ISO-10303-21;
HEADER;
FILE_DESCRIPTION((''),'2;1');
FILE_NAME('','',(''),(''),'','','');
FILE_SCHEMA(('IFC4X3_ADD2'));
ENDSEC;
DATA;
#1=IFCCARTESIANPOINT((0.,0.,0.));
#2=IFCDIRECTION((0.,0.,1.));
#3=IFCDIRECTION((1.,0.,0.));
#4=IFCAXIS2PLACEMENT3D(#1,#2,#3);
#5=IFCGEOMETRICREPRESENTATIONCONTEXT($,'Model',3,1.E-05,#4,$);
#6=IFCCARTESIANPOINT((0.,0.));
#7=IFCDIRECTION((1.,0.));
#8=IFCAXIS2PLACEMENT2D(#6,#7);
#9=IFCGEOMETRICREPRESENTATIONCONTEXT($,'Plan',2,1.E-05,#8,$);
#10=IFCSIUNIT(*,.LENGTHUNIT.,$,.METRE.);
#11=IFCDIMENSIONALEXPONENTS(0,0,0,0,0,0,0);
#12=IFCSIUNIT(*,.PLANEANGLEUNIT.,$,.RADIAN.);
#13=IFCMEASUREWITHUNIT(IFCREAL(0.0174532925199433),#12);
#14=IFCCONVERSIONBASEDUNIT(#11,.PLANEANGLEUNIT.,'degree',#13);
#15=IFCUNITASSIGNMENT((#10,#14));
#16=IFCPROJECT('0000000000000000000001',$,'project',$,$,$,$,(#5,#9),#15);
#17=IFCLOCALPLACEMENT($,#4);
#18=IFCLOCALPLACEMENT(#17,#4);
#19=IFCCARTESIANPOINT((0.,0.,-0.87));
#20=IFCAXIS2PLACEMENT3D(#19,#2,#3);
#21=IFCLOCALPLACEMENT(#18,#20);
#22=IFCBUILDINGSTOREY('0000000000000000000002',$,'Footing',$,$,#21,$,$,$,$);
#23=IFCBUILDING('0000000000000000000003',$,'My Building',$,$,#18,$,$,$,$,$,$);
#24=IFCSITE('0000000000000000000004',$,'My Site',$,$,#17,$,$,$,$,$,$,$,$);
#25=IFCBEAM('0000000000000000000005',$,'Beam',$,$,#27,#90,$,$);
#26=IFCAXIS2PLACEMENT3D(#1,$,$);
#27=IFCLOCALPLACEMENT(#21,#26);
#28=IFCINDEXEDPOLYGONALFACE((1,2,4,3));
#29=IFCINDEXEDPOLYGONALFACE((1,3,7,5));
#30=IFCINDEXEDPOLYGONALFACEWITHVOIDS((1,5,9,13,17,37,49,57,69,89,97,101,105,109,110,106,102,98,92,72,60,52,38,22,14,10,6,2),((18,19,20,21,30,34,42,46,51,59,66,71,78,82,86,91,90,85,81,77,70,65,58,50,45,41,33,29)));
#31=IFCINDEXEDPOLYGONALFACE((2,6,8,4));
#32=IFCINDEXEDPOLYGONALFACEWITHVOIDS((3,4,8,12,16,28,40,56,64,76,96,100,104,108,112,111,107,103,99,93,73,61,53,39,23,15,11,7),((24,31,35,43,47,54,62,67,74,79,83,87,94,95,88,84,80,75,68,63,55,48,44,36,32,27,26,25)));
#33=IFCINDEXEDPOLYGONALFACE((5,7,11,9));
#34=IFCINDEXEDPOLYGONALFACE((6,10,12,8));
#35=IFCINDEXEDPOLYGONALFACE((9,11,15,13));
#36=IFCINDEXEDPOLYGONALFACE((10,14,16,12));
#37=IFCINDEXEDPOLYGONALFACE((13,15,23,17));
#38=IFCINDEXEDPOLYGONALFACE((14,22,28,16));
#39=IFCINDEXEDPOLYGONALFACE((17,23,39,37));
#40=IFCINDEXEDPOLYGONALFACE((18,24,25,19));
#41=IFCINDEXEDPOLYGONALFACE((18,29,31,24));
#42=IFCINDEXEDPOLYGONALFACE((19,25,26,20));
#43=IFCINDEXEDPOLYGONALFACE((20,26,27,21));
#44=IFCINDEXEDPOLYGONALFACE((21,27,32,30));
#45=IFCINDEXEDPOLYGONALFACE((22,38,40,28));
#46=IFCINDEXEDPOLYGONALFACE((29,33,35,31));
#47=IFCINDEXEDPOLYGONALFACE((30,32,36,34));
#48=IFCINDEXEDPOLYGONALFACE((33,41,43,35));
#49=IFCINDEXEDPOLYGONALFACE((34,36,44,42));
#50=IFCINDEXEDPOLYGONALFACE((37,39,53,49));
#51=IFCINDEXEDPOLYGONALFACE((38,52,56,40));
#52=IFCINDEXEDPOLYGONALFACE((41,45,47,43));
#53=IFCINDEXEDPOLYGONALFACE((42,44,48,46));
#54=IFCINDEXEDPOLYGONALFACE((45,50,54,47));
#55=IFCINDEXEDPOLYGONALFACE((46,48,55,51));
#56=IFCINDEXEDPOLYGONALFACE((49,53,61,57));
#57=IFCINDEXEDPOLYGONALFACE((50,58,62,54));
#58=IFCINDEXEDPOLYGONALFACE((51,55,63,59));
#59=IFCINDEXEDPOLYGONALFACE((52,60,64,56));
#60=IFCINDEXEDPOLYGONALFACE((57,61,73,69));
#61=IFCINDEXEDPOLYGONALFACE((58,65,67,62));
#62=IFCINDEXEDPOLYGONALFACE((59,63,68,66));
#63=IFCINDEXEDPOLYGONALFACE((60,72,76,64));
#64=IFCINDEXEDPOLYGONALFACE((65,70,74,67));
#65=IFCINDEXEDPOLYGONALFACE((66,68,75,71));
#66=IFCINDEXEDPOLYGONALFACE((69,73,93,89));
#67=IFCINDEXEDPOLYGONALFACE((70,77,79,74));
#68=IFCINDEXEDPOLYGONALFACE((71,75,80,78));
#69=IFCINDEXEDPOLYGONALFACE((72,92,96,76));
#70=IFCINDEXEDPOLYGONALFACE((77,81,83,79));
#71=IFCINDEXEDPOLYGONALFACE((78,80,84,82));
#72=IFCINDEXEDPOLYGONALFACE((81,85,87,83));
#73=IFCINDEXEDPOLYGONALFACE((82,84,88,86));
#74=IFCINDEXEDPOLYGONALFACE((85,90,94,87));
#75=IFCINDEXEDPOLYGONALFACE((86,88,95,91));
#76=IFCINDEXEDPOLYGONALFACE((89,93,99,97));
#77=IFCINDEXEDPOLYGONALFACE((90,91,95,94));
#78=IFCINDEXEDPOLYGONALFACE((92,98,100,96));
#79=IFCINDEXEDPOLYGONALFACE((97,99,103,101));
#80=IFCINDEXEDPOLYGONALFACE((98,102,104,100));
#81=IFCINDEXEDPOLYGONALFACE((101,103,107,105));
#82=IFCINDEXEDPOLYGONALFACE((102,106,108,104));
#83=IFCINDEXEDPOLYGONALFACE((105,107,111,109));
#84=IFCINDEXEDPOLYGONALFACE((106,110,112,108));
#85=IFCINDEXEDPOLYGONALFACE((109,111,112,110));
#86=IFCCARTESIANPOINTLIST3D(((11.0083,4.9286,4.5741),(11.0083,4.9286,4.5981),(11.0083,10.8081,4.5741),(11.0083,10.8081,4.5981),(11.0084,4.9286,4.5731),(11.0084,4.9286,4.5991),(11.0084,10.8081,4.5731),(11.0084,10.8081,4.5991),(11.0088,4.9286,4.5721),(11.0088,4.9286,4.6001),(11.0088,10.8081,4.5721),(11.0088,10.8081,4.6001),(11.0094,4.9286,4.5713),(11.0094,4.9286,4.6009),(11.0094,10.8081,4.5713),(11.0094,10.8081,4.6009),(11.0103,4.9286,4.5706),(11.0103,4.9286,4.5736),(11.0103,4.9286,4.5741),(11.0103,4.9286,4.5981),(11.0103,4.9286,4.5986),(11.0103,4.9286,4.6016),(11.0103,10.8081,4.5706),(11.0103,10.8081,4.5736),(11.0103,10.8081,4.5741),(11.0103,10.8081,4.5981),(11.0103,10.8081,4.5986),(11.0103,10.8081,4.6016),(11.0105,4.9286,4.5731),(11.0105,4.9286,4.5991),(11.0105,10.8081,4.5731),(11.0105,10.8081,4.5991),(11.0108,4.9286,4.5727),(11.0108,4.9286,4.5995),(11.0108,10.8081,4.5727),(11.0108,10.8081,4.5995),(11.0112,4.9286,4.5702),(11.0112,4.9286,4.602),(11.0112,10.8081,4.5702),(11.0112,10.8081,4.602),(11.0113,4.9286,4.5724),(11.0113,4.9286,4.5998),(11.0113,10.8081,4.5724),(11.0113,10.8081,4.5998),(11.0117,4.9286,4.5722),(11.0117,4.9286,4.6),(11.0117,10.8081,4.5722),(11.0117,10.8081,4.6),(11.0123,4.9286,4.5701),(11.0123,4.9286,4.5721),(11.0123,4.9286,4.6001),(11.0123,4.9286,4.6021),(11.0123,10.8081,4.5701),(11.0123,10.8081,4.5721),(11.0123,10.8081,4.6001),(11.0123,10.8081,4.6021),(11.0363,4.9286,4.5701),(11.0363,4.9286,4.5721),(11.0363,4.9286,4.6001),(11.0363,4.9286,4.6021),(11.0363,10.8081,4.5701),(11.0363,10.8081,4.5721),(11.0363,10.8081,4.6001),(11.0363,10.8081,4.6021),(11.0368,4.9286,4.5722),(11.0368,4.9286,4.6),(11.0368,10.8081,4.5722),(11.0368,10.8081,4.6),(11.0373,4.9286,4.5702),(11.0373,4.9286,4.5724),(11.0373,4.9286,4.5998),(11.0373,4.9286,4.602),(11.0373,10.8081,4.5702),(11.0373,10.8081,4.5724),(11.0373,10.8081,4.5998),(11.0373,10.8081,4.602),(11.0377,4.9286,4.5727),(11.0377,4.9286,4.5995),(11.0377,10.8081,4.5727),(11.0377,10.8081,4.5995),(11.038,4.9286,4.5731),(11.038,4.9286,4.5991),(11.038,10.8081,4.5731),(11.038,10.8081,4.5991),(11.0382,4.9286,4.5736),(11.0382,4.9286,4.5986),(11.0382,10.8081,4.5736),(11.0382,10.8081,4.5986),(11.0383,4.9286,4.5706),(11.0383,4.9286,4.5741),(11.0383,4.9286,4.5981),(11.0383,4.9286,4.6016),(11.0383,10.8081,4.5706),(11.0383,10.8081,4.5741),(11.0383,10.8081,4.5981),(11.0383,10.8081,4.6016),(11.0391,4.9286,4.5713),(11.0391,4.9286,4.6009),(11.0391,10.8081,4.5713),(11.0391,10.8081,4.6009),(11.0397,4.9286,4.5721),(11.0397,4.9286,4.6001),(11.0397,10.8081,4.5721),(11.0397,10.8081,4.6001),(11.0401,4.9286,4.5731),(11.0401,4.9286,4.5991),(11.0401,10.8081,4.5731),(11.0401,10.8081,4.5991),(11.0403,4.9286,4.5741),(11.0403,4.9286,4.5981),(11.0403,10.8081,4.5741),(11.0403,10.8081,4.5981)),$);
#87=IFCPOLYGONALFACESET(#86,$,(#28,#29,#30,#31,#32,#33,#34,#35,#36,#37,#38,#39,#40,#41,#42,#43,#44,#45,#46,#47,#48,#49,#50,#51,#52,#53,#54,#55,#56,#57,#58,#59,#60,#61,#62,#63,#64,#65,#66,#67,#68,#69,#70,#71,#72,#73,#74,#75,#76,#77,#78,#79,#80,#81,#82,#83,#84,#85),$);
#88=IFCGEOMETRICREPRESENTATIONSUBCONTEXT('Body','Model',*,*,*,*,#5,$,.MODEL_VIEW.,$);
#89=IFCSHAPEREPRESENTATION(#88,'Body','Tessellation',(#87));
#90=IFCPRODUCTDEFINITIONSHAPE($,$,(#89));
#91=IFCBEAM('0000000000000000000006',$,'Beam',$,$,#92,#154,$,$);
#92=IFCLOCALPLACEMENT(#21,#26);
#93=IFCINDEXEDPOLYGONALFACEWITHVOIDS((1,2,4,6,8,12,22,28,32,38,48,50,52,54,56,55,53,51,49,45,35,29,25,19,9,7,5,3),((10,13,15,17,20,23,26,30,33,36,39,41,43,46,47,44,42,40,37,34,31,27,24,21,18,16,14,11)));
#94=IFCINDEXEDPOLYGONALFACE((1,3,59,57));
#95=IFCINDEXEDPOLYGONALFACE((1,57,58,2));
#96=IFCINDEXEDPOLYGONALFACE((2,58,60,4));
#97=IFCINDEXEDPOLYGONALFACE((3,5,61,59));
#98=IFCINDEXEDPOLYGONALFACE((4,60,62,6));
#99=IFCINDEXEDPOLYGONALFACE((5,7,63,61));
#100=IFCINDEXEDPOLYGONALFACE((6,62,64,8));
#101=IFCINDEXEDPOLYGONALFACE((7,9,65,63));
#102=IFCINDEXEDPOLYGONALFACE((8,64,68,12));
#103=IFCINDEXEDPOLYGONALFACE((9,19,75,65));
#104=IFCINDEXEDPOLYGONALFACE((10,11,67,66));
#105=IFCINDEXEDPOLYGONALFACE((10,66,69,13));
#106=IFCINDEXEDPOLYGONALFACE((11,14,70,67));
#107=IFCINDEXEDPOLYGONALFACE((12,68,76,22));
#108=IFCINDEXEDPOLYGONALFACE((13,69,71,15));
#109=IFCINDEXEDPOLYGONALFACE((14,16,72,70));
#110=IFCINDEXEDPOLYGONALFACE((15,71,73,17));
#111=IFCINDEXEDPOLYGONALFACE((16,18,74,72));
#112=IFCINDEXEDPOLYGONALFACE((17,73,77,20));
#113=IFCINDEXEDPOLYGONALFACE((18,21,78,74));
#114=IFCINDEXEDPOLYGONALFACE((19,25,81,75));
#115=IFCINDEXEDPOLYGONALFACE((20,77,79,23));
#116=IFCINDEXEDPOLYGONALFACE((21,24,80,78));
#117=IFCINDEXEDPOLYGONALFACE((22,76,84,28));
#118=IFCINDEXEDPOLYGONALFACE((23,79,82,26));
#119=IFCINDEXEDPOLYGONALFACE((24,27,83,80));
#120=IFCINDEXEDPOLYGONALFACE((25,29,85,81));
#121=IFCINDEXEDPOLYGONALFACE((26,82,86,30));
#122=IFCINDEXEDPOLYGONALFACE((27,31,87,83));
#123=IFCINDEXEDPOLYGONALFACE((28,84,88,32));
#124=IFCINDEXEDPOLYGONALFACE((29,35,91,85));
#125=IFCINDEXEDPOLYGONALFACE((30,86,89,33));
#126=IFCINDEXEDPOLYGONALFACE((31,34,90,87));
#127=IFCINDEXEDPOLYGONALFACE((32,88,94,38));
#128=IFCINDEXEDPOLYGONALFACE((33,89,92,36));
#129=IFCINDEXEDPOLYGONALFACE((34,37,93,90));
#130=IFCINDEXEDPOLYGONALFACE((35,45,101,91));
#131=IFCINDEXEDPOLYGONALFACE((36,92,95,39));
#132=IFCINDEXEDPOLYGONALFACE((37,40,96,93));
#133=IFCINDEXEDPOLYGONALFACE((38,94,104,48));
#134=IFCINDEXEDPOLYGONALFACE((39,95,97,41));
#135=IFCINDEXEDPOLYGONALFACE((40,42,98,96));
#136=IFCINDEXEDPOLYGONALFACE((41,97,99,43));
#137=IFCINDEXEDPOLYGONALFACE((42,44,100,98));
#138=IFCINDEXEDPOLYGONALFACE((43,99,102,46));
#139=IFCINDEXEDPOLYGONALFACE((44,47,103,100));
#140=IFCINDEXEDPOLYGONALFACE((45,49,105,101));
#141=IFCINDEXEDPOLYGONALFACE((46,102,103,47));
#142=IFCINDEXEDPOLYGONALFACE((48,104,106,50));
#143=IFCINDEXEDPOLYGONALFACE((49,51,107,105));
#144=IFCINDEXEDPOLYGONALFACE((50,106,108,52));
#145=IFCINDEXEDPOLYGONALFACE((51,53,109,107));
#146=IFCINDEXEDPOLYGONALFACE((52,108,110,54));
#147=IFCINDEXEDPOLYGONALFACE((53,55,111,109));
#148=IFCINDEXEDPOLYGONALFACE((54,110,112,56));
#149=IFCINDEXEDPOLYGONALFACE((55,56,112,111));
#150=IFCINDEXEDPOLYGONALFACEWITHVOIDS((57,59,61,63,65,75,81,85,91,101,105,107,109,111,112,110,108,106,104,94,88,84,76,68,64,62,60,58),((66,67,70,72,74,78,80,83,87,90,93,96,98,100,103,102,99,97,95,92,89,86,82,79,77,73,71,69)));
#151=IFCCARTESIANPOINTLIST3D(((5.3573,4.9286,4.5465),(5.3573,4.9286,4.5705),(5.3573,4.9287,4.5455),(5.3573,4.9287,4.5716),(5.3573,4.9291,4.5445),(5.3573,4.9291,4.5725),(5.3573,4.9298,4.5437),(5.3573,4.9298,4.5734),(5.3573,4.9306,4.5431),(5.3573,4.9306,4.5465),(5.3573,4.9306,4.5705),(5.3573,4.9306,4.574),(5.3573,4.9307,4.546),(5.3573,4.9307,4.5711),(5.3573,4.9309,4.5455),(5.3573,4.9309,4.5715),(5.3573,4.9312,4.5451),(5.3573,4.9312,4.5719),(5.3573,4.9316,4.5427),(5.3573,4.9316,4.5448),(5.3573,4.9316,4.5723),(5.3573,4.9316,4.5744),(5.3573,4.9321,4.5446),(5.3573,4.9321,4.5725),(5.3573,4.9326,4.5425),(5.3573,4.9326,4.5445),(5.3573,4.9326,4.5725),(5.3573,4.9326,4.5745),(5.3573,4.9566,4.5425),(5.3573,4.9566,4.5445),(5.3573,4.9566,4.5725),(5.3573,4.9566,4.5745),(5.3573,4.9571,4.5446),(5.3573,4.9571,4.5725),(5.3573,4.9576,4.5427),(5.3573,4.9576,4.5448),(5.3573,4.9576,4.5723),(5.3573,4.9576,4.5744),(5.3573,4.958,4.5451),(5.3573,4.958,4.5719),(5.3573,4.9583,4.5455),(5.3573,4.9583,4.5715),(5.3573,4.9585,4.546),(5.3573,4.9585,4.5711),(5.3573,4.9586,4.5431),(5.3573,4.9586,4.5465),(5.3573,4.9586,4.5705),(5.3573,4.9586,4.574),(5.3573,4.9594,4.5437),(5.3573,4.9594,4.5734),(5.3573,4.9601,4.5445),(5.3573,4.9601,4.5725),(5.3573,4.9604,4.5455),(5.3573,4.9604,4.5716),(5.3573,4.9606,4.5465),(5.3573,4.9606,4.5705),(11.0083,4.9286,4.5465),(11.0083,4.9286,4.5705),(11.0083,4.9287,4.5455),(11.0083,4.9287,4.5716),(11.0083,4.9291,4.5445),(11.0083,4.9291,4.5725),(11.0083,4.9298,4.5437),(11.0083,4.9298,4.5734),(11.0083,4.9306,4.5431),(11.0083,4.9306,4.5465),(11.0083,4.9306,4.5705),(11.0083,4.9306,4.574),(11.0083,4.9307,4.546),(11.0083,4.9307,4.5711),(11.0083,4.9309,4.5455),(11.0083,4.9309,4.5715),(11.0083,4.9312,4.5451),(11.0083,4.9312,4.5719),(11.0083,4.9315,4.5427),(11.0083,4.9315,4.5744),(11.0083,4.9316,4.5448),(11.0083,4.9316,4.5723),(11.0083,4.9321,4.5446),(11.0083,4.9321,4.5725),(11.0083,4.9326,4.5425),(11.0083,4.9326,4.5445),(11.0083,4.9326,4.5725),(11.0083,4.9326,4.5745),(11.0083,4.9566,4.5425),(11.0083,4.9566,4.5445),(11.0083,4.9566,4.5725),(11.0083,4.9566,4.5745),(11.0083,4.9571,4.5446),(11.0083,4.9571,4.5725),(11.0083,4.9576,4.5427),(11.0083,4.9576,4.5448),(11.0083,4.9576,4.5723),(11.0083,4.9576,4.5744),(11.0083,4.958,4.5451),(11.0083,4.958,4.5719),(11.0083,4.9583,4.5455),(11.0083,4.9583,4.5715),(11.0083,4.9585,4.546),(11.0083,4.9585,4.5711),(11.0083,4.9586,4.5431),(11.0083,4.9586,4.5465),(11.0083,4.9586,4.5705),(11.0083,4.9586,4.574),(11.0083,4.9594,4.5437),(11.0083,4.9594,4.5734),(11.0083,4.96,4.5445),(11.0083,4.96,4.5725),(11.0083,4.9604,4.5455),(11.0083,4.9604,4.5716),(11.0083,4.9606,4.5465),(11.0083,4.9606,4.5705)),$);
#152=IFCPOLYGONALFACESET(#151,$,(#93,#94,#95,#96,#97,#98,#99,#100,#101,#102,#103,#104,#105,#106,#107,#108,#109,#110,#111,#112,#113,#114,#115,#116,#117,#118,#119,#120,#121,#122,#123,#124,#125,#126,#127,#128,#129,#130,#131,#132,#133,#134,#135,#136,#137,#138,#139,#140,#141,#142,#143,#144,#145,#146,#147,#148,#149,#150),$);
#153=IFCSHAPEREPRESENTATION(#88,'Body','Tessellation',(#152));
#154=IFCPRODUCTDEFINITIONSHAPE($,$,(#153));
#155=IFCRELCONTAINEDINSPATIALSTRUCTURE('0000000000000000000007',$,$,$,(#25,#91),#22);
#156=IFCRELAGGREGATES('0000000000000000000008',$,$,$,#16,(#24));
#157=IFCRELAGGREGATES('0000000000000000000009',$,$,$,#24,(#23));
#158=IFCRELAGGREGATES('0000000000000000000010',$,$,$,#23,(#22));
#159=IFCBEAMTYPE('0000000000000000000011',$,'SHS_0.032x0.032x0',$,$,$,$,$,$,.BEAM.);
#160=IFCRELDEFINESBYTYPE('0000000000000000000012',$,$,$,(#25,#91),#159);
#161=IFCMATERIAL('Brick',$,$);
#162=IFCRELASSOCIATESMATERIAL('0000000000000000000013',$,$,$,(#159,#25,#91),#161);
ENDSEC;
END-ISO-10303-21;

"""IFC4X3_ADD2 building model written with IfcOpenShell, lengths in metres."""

from ifc_helpers import new_model, entity, si_unit, converted_unit, frame, origin_with_axes, origin_2d_with_axis, place, context, subcontext, project, spatial, hollow_rectangle, extrude, material, material_profile, profile_set, profile_usage, type_object, element, save


model = new_model("IFC4X3_ADD2")

# Units and contexts
model_context = context("Model", 3, precision=1e-05, world=origin_with_axes())
plan_context = context("Plan", 2, precision=1e-05, world=origin_2d_with_axis())
body_context = subcontext(model_context, "Body", "Model", "MODEL_VIEW")
ifc_project = project(units=[si_unit("LENGTHUNIT", "METRE"), converted_unit("PLANEANGLEUNIT", "degree", entity("IfcReal", 0.0174532925199433), si_unit("PLANEANGLEUNIT", "RADIAN"), dimensions=[0, 0, 0, 0, 0, 0, 0])], contexts=[model_context, plan_context])

# Site, building, storey
site_placement = place(None, origin_with_axes())
site = spatial("IfcSite", under=ifc_project, at=site_placement, Name="My Site")
building_placement = place(site_placement, origin_with_axes())
building = spatial("IfcBuilding", under=site, at=building_placement, Name="My Building")
storey_placement = place(building_placement, frame((0.0, 0.0, -0.87), z_axis=(0.0, 0.0, 1.0), x_axis=(1.0, 0.0, 0.0)))
storey = spatial("IfcBuildingStorey", under=building, at=storey_placement, Name="Footing")

# Beams
ifc_material_1 = material(Name="Brick")
ifc_material_profile = material_profile(ifc_material_1, hollow_rectangle(XDim=0.032, YDim=0.032, WallThickness=0.002, InnerFilletRadius=0.002, OuterFilletRadius=0.004))
ifc_profile_set = profile_set([ifc_material_profile])
beam_type_1 = type_object("IfcBeamType", Name="SHS_0.032x0.032x0", PredefinedType="BEAM", material=ifc_profile_set)
ifc_profile_usage_1 = profile_usage(ifc_profile_set, cardinal=5)
beam_1_placement = place(storey_placement, frame((11.0243, 4.9286, 4.5861), z_axis=(0.0, 1.0, 0.0), x_axis=(-1.0, 0.0, 0.0)))
element("IfcBeam", 1, at=beam_1_placement, inside=storey, type_object=beam_type_1, material=ifc_profile_usage_1, Name="Beam", context=body_context, shape_type="SweptSolid", body=[
    extrude(hollow_rectangle(XDim=0.032, YDim=0.032, WallThickness=0.002, InnerFilletRadius=0.002, OuterFilletRadius=0.004), origin_with_axes(), (0.0, 0.0, 1.0), 5.8795),
])
ifc_profile_usage_2 = profile_usage(ifc_profile_set, cardinal=5)
beam_2_placement = place(storey_placement, frame((5.3573, 4.9446, 4.5585), z_axis=(1.0, 0.0, 0.0), x_axis=(0.0, 1.0, 0.0)))
element("IfcBeam", 2, at=beam_2_placement, inside=storey, type_object=beam_type_1, material=ifc_profile_usage_2, Name="Beam", context=body_context, shape_type="SweptSolid", body=[
    extrude(hollow_rectangle(XDim=0.032, YDim=0.032, WallThickness=0.002, InnerFilletRadius=0.002, OuterFilletRadius=0.004), origin_with_axes(), (0.0, 0.0, 1.0), 5.651),
])

save(model, "model.ifc")
